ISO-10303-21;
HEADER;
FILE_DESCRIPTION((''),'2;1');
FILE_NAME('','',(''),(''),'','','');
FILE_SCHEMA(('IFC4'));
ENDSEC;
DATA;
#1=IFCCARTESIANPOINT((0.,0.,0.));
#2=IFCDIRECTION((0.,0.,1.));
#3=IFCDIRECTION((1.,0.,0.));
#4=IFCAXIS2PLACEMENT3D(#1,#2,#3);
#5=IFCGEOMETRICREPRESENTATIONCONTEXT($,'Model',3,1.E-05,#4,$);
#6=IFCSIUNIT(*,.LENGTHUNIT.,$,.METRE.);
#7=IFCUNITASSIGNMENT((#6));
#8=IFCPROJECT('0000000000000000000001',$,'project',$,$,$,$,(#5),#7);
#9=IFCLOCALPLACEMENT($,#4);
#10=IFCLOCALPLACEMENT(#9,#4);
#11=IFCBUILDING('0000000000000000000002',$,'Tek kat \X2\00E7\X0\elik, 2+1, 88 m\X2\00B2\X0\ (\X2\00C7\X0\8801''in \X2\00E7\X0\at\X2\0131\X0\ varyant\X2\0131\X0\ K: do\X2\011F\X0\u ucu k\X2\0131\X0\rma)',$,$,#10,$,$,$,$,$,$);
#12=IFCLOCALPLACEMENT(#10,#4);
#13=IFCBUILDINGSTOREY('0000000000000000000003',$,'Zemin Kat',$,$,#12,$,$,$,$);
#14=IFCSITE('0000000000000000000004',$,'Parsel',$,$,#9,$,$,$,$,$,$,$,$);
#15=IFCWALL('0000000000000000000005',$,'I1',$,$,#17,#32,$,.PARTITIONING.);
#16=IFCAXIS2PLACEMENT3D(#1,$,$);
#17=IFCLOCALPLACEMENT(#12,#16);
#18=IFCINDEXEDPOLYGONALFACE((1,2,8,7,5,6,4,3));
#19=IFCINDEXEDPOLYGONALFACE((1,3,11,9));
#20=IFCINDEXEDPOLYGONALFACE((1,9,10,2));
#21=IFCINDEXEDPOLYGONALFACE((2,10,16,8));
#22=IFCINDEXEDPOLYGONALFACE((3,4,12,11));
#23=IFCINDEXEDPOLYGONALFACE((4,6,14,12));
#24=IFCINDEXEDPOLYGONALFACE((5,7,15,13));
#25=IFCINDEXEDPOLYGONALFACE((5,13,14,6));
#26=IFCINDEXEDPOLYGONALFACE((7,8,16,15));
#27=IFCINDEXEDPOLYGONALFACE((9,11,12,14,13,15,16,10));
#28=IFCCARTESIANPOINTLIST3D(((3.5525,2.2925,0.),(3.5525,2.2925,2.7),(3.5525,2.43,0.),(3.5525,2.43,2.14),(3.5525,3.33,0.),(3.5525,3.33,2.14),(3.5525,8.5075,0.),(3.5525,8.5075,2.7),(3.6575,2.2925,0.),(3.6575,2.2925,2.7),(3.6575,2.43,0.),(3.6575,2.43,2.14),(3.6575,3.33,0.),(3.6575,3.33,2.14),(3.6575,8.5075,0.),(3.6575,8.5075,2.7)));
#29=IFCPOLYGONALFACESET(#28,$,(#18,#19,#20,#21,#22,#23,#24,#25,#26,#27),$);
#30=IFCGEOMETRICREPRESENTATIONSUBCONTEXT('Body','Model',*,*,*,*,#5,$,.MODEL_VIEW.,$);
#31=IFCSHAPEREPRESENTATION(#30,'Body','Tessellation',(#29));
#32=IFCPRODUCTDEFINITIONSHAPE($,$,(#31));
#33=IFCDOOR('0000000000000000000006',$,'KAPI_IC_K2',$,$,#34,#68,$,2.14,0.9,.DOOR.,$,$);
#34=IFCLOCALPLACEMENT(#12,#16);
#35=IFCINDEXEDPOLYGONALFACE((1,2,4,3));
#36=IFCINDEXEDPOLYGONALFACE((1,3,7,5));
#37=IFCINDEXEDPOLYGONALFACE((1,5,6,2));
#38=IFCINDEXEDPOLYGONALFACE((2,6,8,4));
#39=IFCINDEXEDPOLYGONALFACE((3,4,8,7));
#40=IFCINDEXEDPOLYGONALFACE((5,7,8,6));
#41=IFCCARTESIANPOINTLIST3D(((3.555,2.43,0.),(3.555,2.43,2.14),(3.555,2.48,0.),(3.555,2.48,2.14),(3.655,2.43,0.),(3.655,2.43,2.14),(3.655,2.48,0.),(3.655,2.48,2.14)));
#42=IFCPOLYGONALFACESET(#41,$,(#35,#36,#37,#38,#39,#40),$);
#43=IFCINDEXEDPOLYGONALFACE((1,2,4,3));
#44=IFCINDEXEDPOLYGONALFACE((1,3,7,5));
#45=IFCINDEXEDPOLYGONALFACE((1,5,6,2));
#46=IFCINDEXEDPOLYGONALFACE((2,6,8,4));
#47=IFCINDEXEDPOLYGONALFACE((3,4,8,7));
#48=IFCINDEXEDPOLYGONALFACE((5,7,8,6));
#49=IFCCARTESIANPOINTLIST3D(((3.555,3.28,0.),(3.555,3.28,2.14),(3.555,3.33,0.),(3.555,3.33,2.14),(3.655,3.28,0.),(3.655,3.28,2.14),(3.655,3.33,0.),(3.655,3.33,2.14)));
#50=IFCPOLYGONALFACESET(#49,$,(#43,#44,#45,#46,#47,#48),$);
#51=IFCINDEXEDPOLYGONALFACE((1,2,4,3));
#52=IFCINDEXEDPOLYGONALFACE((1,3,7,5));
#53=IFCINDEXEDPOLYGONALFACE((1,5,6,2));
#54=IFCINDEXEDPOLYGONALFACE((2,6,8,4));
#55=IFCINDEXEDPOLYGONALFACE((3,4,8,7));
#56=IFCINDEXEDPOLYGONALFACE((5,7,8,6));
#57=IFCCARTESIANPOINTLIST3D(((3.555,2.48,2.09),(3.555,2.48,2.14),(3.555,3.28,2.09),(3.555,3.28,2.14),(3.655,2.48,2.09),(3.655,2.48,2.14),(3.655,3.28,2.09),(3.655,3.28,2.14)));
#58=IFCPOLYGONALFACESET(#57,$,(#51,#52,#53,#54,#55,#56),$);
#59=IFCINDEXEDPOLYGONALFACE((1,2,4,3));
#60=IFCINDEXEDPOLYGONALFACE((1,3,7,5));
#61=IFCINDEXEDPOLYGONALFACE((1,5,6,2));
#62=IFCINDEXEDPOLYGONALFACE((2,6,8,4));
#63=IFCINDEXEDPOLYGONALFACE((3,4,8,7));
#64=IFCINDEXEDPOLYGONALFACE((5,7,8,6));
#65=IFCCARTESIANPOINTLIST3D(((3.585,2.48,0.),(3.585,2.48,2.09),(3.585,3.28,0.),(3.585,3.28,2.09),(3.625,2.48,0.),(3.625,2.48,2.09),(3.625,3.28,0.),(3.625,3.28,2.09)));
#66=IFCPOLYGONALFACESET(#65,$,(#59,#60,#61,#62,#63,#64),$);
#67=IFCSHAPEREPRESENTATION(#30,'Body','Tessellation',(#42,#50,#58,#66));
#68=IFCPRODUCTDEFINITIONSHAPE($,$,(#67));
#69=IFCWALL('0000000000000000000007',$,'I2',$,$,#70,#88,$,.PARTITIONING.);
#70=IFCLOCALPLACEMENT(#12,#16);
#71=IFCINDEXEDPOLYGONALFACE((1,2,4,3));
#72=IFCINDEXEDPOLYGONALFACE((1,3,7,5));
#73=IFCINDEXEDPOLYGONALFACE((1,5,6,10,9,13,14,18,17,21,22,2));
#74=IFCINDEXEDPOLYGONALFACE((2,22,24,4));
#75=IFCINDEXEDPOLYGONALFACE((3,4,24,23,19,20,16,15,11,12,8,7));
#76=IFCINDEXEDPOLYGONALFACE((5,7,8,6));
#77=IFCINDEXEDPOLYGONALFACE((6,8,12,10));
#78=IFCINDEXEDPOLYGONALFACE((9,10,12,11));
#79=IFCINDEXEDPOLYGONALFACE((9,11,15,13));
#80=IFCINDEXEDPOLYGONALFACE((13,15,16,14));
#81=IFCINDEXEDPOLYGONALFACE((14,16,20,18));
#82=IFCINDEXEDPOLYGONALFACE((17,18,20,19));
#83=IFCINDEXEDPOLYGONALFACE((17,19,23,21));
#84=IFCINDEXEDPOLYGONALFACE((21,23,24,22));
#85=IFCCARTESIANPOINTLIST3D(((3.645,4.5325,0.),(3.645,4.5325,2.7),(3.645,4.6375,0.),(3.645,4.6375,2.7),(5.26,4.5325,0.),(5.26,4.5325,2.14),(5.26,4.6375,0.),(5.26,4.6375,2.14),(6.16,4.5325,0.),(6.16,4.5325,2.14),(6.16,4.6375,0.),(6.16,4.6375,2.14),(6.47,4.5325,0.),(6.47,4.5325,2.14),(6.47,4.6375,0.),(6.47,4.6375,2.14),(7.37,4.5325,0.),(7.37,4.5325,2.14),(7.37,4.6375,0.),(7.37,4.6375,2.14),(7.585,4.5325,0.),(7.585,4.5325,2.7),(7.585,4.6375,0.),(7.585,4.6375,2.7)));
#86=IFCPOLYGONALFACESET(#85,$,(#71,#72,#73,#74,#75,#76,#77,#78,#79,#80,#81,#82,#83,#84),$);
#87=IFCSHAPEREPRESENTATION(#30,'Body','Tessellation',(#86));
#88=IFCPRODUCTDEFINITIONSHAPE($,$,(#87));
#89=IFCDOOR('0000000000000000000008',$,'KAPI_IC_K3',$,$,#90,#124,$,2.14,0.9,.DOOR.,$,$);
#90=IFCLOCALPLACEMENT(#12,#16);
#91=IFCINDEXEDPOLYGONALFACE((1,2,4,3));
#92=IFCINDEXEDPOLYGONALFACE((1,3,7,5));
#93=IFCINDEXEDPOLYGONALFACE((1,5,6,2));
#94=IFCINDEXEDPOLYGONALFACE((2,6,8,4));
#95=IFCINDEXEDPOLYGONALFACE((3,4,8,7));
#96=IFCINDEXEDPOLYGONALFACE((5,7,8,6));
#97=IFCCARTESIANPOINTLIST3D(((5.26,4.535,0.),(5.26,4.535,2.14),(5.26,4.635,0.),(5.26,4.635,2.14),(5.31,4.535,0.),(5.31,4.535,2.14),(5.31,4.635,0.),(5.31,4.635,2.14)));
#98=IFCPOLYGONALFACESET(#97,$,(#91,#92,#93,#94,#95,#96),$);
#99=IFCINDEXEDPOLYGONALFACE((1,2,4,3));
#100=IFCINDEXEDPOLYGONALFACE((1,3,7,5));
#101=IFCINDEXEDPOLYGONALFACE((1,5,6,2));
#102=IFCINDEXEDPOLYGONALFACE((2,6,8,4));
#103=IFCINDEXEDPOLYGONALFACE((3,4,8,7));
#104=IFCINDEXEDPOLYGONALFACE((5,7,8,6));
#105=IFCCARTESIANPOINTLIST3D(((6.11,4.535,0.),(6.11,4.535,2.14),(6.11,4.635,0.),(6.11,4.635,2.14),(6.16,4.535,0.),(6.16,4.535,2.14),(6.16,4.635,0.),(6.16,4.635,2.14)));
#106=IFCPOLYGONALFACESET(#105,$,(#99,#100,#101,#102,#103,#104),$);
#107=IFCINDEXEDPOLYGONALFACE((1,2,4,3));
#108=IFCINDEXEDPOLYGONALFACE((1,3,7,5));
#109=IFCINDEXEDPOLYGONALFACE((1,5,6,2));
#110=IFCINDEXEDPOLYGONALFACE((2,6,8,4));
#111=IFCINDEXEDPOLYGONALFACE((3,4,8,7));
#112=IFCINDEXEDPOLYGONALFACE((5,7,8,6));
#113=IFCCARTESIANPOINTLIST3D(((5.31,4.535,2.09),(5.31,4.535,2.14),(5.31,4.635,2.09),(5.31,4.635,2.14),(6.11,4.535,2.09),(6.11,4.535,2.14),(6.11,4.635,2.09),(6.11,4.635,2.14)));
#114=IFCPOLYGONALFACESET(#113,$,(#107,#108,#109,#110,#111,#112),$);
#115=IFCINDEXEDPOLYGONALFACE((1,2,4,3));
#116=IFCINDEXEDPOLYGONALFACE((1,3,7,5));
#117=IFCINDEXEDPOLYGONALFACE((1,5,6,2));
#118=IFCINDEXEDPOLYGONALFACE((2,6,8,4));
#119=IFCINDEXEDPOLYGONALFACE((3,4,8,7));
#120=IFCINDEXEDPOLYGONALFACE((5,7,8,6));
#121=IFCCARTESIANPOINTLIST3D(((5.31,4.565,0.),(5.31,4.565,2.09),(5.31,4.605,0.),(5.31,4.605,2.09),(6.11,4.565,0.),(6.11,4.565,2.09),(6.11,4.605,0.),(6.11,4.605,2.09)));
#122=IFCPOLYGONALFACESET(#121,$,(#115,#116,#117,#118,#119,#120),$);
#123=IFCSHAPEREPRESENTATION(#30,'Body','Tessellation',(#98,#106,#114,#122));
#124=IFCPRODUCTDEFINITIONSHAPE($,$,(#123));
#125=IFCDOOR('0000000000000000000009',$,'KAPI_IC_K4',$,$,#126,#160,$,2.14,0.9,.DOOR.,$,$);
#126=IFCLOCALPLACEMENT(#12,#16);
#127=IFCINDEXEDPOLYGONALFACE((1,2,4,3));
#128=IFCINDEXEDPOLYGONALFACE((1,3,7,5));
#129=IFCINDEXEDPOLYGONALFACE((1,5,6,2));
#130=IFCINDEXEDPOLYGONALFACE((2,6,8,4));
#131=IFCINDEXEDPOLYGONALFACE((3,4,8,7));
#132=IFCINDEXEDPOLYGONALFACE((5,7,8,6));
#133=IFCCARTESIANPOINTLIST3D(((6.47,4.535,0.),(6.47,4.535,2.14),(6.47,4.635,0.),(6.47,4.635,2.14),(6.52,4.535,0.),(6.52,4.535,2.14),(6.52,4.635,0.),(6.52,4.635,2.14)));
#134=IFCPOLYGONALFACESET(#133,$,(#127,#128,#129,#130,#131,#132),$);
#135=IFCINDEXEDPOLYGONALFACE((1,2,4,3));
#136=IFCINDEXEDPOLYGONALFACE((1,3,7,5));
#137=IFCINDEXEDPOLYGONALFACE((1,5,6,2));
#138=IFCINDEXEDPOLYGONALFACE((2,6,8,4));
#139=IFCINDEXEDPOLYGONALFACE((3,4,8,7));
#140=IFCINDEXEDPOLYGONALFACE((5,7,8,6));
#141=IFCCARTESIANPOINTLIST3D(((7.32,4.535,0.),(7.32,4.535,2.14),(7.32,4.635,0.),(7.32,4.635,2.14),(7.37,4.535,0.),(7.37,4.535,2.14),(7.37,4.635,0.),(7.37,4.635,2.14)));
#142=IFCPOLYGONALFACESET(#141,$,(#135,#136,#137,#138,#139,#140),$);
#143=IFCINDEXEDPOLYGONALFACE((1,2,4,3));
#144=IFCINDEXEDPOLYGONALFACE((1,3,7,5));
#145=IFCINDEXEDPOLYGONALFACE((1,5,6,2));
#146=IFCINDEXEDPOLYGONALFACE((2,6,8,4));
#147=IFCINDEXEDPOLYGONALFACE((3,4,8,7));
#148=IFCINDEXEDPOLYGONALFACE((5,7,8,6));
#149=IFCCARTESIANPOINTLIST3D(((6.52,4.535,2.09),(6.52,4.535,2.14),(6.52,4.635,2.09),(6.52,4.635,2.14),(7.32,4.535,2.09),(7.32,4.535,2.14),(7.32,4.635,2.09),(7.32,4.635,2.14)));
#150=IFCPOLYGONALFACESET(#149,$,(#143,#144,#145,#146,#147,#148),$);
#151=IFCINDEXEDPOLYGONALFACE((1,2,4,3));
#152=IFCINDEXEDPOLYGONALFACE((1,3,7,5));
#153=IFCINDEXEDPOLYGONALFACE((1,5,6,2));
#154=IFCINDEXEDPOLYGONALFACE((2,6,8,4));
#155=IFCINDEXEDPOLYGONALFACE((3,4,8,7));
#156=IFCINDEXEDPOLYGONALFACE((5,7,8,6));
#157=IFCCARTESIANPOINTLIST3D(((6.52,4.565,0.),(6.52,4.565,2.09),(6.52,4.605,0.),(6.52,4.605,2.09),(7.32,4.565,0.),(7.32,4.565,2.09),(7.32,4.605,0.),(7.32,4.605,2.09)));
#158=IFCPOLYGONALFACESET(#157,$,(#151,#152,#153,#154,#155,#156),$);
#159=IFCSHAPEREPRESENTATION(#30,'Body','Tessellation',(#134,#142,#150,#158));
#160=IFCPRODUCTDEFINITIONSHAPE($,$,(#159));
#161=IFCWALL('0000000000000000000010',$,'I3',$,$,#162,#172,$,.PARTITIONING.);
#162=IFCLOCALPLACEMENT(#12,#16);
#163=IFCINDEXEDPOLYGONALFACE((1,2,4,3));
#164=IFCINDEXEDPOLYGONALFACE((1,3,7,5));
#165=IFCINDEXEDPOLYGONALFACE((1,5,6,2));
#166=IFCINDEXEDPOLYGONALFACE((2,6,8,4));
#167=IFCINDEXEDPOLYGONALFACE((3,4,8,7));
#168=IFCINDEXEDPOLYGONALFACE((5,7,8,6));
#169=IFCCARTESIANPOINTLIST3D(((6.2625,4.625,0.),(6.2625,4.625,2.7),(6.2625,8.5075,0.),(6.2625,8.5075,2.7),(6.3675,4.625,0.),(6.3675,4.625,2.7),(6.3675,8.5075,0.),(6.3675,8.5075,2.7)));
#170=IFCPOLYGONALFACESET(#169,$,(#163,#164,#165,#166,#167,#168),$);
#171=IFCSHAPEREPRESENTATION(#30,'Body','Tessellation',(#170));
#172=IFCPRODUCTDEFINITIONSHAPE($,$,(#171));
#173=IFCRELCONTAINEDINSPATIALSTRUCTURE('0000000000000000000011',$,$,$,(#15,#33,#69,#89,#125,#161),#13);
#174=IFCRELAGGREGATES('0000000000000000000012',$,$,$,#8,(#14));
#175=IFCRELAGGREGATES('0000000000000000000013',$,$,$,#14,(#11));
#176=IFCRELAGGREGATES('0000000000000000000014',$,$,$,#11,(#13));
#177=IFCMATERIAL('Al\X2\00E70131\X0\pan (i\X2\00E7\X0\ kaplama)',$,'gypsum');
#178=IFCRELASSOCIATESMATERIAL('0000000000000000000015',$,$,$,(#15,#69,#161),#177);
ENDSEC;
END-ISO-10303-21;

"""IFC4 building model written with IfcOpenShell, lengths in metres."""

from ifc_helpers import new_model, si_unit, frame, origin_with_axes, place, context, subcontext, project, spatial, line, indexed_curve, outline, extrude, material, element, fill, save


model = new_model("IFC4")

# Units and contexts
model_context = context("Model", 3, precision=1e-05, world=origin_with_axes())
body_context = subcontext(model_context, "Body", "Model", "MODEL_VIEW")
ifc_project = project(units=[si_unit("LENGTHUNIT", "METRE")], contexts=[model_context])

# Site, building, storey
site_placement = place(None, origin_with_axes())
site = spatial("IfcSite", under=ifc_project, at=site_placement, Name="Parsel")
building_placement = place(site_placement, origin_with_axes())
building = spatial("IfcBuilding", under=site, at=building_placement, Name="Tek kat çelik, 2+1, 88 m² (Ç8801'in çatı varyantı K: doğu ucu kırma)")
storey_placement = place(building_placement, origin_with_axes())
storey = spatial("IfcBuildingStorey", under=building, at=storey_placement, Name="Zemin Kat")

# Wall, opening, door
ifc_material_1 = material(Name="Alçıpan (iç kaplama)", Category="gypsum")
wall_1_placement = place(storey_placement, origin_with_axes())
wall_1 = element("IfcWall", 1, at=wall_1_placement, inside=storey, material=ifc_material_1, Name="I1", PredefinedType="PARTITIONING", context=body_context, shape_type="SweptSolid", body=[
    extrude(outline(indexed_curve([(0.0, 0.0), (0.105, 0.0), (0.105, 6.215), (0.0, 6.215)], segments=[line(1, 2, 3, 4, 1)])), frame((3.5525, 2.2925, 0.0), z_axis=(0.0, 0.0, 1.0), x_axis=(1.0, 0.0, 0.0)), (0.0, 0.0, 1.0), 2.7),
])
opening_1_placement = place(wall_1_placement, origin_with_axes())
opening_1 = element("IfcOpeningElement", 2, at=opening_1_placement, cuts=wall_1, PredefinedType="OPENING", context=body_context, shape_type="SweptSolid", body=[
    extrude(outline(indexed_curve([(0.0, 0.0), (0.145, 0.0), (0.145, 0.9), (0.0, 0.9)], segments=[line(1, 2, 3, 4, 1)])), frame((3.5325, 2.43, 0.0), z_axis=(0.0, 0.0, 1.0), x_axis=(1.0, 0.0, 0.0)), (0.0, 0.0, 1.0), 2.14),
])
door_1_placement = place(storey_placement, origin_with_axes())
door_1 = element("IfcDoor", 3, at=door_1_placement, inside=storey, Name="KAPI_IC_K2", OverallHeight=2.14, OverallWidth=0.9, PredefinedType="DOOR", context=body_context, shape_type="SweptSolid", body=[
    extrude(outline(indexed_curve([(0.0, 0.0), (0.1, 0.0), (0.1, 0.05), (0.0, 0.05)], segments=[line(1, 2, 3, 4, 1)])), frame((3.555, 2.43, 0.0), z_axis=(0.0, 0.0, 1.0), x_axis=(1.0, 0.0, 0.0)), (0.0, 0.0, 1.0), 2.14),
    extrude(outline(indexed_curve([(0.0, 0.0), (0.1, 0.0), (0.1, 0.05), (0.0, 0.05)], segments=[line(1, 2, 3, 4, 1)])), frame((3.555, 3.28, 0.0), z_axis=(0.0, 0.0, 1.0), x_axis=(1.0, 0.0, 0.0)), (0.0, 0.0, 1.0), 2.14),
    extrude(outline(indexed_curve([(0.0, 0.0), (0.1, 0.0), (0.1, 0.8), (0.0, 0.8)], segments=[line(1, 2, 3, 4, 1)])), frame((3.555, 2.48, 2.09), z_axis=(0.0, 0.0, 1.0), x_axis=(1.0, 0.0, 0.0)), (0.0, 0.0, 1.0), 0.05),
    extrude(outline(indexed_curve([(0.0, 0.0), (0.04, 0.0), (0.04, 0.8), (0.0, 0.8)], segments=[line(1, 2, 3, 4, 1)])), frame((3.585, 2.48, 0.0), z_axis=(0.0, 0.0, 1.0), x_axis=(1.0, 0.0, 0.0)), (0.0, 0.0, 1.0), 2.09),
])
fill(opening_1, door_1)

# Wall, openings, doors
wall_2_placement = place(storey_placement, origin_with_axes())
wall_2 = element("IfcWall", 4, at=wall_2_placement, inside=storey, material=ifc_material_1, Name="I2", PredefinedType="PARTITIONING", context=body_context, shape_type="SweptSolid", body=[
    extrude(outline(indexed_curve([(0.0, 0.0), (3.94, 0.0), (3.94, 0.105), (0.0, 0.105)], segments=[line(1, 2, 3, 4, 1)])), frame((3.645, 4.5325, 0.0), z_axis=(0.0, 0.0, 1.0), x_axis=(1.0, 0.0, 0.0)), (0.0, 0.0, 1.0), 2.7),
])
opening_2_placement = place(wall_2_placement, origin_with_axes())
opening_2 = element("IfcOpeningElement", 5, at=opening_2_placement, cuts=wall_2, PredefinedType="OPENING", context=body_context, shape_type="SweptSolid", body=[
    extrude(outline(indexed_curve([(0.0, 0.0), (0.9, 0.0), (0.9, 0.145), (0.0, 0.145)], segments=[line(1, 2, 3, 4, 1)])), frame((5.26, 4.5125, 0.0), z_axis=(0.0, 0.0, 1.0), x_axis=(1.0, 0.0, 0.0)), (0.0, 0.0, 1.0), 2.14),
])
opening_3_placement = place(wall_2_placement, origin_with_axes())
opening_3 = element("IfcOpeningElement", 6, at=opening_3_placement, cuts=wall_2, PredefinedType="OPENING", context=body_context, shape_type="SweptSolid", body=[
    extrude(outline(indexed_curve([(0.0, 0.0), (0.9, 0.0), (0.9, 0.145), (0.0, 0.145)], segments=[line(1, 2, 3, 4, 1)])), frame((6.47, 4.5125, 0.0), z_axis=(0.0, 0.0, 1.0), x_axis=(1.0, 0.0, 0.0)), (0.0, 0.0, 1.0), 2.14),
])
door_2_placement = place(storey_placement, origin_with_axes())
door_2 = element("IfcDoor", 7, at=door_2_placement, inside=storey, Name="KAPI_IC_K3", OverallHeight=2.14, OverallWidth=0.9, PredefinedType="DOOR", context=body_context, shape_type="SweptSolid", body=[
    extrude(outline(indexed_curve([(0.0, 0.0), (0.05, 0.0), (0.05, 0.1), (0.0, 0.1)], segments=[line(1, 2, 3, 4, 1)])), frame((5.26, 4.535, 0.0), z_axis=(0.0, 0.0, 1.0), x_axis=(1.0, 0.0, 0.0)), (0.0, 0.0, 1.0), 2.14),
    extrude(outline(indexed_curve([(0.0, 0.0), (0.05, 0.0), (0.05, 0.1), (0.0, 0.1)], segments=[line(1, 2, 3, 4, 1)])), frame((6.11, 4.535, 0.0), z_axis=(0.0, 0.0, 1.0), x_axis=(1.0, 0.0, 0.0)), (0.0, 0.0, 1.0), 2.14),
    extrude(outline(indexed_curve([(0.0, 0.0), (0.8, 0.0), (0.8, 0.1), (0.0, 0.1)], segments=[line(1, 2, 3, 4, 1)])), frame((5.31, 4.535, 2.09), z_axis=(0.0, 0.0, 1.0), x_axis=(1.0, 0.0, 0.0)), (0.0, 0.0, 1.0), 0.05),
    extrude(outline(indexed_curve([(0.0, 0.0), (0.8, 0.0), (0.8, 0.04), (0.0, 0.04)], segments=[line(1, 2, 3, 4, 1)])), frame((5.31, 4.565, 0.0), z_axis=(0.0, 0.0, 1.0), x_axis=(1.0, 0.0, 0.0)), (0.0, 0.0, 1.0), 2.09),
])
fill(opening_2, door_2)
door_3_placement = place(storey_placement, origin_with_axes())
door_3 = element("IfcDoor", 8, at=door_3_placement, inside=storey, Name="KAPI_IC_K4", OverallHeight=2.14, OverallWidth=0.9, PredefinedType="DOOR", context=body_context, shape_type="SweptSolid", body=[
    extrude(outline(indexed_curve([(0.0, 0.0), (0.05, 0.0), (0.05, 0.1), (0.0, 0.1)], segments=[line(1, 2, 3, 4, 1)])), frame((6.47, 4.535, 0.0), z_axis=(0.0, 0.0, 1.0), x_axis=(1.0, 0.0, 0.0)), (0.0, 0.0, 1.0), 2.14),
    extrude(outline(indexed_curve([(0.0, 0.0), (0.05, 0.0), (0.05, 0.1), (0.0, 0.1)], segments=[line(1, 2, 3, 4, 1)])), frame((7.32, 4.535, 0.0), z_axis=(0.0, 0.0, 1.0), x_axis=(1.0, 0.0, 0.0)), (0.0, 0.0, 1.0), 2.14),
    extrude(outline(indexed_curve([(0.0, 0.0), (0.8, 0.0), (0.8, 0.1), (0.0, 0.1)], segments=[line(1, 2, 3, 4, 1)])), frame((6.52, 4.535, 2.09), z_axis=(0.0, 0.0, 1.0), x_axis=(1.0, 0.0, 0.0)), (0.0, 0.0, 1.0), 0.05),
    extrude(outline(indexed_curve([(0.0, 0.0), (0.8, 0.0), (0.8, 0.04), (0.0, 0.04)], segments=[line(1, 2, 3, 4, 1)])), frame((6.52, 4.565, 0.0), z_axis=(0.0, 0.0, 1.0), x_axis=(1.0, 0.0, 0.0)), (0.0, 0.0, 1.0), 2.09),
])
fill(opening_3, door_3)

# Wall
wall_3_placement = place(storey_placement, origin_with_axes())
element("IfcWall", 9, at=wall_3_placement, inside=storey, material=ifc_material_1, Name="I3", PredefinedType="PARTITIONING", context=body_context, shape_type="SweptSolid", body=[
    extrude(outline(indexed_curve([(0.0, 0.0), (0.105, 0.0), (0.105, 3.8825), (0.0, 3.8825)], segments=[line(1, 2, 3, 4, 1)])), frame((6.2625, 4.625, 0.0), z_axis=(0.0, 0.0, 1.0), x_axis=(1.0, 0.0, 0.0)), (0.0, 0.0, 1.0), 2.7),
])

save(model, "model.ifc")
